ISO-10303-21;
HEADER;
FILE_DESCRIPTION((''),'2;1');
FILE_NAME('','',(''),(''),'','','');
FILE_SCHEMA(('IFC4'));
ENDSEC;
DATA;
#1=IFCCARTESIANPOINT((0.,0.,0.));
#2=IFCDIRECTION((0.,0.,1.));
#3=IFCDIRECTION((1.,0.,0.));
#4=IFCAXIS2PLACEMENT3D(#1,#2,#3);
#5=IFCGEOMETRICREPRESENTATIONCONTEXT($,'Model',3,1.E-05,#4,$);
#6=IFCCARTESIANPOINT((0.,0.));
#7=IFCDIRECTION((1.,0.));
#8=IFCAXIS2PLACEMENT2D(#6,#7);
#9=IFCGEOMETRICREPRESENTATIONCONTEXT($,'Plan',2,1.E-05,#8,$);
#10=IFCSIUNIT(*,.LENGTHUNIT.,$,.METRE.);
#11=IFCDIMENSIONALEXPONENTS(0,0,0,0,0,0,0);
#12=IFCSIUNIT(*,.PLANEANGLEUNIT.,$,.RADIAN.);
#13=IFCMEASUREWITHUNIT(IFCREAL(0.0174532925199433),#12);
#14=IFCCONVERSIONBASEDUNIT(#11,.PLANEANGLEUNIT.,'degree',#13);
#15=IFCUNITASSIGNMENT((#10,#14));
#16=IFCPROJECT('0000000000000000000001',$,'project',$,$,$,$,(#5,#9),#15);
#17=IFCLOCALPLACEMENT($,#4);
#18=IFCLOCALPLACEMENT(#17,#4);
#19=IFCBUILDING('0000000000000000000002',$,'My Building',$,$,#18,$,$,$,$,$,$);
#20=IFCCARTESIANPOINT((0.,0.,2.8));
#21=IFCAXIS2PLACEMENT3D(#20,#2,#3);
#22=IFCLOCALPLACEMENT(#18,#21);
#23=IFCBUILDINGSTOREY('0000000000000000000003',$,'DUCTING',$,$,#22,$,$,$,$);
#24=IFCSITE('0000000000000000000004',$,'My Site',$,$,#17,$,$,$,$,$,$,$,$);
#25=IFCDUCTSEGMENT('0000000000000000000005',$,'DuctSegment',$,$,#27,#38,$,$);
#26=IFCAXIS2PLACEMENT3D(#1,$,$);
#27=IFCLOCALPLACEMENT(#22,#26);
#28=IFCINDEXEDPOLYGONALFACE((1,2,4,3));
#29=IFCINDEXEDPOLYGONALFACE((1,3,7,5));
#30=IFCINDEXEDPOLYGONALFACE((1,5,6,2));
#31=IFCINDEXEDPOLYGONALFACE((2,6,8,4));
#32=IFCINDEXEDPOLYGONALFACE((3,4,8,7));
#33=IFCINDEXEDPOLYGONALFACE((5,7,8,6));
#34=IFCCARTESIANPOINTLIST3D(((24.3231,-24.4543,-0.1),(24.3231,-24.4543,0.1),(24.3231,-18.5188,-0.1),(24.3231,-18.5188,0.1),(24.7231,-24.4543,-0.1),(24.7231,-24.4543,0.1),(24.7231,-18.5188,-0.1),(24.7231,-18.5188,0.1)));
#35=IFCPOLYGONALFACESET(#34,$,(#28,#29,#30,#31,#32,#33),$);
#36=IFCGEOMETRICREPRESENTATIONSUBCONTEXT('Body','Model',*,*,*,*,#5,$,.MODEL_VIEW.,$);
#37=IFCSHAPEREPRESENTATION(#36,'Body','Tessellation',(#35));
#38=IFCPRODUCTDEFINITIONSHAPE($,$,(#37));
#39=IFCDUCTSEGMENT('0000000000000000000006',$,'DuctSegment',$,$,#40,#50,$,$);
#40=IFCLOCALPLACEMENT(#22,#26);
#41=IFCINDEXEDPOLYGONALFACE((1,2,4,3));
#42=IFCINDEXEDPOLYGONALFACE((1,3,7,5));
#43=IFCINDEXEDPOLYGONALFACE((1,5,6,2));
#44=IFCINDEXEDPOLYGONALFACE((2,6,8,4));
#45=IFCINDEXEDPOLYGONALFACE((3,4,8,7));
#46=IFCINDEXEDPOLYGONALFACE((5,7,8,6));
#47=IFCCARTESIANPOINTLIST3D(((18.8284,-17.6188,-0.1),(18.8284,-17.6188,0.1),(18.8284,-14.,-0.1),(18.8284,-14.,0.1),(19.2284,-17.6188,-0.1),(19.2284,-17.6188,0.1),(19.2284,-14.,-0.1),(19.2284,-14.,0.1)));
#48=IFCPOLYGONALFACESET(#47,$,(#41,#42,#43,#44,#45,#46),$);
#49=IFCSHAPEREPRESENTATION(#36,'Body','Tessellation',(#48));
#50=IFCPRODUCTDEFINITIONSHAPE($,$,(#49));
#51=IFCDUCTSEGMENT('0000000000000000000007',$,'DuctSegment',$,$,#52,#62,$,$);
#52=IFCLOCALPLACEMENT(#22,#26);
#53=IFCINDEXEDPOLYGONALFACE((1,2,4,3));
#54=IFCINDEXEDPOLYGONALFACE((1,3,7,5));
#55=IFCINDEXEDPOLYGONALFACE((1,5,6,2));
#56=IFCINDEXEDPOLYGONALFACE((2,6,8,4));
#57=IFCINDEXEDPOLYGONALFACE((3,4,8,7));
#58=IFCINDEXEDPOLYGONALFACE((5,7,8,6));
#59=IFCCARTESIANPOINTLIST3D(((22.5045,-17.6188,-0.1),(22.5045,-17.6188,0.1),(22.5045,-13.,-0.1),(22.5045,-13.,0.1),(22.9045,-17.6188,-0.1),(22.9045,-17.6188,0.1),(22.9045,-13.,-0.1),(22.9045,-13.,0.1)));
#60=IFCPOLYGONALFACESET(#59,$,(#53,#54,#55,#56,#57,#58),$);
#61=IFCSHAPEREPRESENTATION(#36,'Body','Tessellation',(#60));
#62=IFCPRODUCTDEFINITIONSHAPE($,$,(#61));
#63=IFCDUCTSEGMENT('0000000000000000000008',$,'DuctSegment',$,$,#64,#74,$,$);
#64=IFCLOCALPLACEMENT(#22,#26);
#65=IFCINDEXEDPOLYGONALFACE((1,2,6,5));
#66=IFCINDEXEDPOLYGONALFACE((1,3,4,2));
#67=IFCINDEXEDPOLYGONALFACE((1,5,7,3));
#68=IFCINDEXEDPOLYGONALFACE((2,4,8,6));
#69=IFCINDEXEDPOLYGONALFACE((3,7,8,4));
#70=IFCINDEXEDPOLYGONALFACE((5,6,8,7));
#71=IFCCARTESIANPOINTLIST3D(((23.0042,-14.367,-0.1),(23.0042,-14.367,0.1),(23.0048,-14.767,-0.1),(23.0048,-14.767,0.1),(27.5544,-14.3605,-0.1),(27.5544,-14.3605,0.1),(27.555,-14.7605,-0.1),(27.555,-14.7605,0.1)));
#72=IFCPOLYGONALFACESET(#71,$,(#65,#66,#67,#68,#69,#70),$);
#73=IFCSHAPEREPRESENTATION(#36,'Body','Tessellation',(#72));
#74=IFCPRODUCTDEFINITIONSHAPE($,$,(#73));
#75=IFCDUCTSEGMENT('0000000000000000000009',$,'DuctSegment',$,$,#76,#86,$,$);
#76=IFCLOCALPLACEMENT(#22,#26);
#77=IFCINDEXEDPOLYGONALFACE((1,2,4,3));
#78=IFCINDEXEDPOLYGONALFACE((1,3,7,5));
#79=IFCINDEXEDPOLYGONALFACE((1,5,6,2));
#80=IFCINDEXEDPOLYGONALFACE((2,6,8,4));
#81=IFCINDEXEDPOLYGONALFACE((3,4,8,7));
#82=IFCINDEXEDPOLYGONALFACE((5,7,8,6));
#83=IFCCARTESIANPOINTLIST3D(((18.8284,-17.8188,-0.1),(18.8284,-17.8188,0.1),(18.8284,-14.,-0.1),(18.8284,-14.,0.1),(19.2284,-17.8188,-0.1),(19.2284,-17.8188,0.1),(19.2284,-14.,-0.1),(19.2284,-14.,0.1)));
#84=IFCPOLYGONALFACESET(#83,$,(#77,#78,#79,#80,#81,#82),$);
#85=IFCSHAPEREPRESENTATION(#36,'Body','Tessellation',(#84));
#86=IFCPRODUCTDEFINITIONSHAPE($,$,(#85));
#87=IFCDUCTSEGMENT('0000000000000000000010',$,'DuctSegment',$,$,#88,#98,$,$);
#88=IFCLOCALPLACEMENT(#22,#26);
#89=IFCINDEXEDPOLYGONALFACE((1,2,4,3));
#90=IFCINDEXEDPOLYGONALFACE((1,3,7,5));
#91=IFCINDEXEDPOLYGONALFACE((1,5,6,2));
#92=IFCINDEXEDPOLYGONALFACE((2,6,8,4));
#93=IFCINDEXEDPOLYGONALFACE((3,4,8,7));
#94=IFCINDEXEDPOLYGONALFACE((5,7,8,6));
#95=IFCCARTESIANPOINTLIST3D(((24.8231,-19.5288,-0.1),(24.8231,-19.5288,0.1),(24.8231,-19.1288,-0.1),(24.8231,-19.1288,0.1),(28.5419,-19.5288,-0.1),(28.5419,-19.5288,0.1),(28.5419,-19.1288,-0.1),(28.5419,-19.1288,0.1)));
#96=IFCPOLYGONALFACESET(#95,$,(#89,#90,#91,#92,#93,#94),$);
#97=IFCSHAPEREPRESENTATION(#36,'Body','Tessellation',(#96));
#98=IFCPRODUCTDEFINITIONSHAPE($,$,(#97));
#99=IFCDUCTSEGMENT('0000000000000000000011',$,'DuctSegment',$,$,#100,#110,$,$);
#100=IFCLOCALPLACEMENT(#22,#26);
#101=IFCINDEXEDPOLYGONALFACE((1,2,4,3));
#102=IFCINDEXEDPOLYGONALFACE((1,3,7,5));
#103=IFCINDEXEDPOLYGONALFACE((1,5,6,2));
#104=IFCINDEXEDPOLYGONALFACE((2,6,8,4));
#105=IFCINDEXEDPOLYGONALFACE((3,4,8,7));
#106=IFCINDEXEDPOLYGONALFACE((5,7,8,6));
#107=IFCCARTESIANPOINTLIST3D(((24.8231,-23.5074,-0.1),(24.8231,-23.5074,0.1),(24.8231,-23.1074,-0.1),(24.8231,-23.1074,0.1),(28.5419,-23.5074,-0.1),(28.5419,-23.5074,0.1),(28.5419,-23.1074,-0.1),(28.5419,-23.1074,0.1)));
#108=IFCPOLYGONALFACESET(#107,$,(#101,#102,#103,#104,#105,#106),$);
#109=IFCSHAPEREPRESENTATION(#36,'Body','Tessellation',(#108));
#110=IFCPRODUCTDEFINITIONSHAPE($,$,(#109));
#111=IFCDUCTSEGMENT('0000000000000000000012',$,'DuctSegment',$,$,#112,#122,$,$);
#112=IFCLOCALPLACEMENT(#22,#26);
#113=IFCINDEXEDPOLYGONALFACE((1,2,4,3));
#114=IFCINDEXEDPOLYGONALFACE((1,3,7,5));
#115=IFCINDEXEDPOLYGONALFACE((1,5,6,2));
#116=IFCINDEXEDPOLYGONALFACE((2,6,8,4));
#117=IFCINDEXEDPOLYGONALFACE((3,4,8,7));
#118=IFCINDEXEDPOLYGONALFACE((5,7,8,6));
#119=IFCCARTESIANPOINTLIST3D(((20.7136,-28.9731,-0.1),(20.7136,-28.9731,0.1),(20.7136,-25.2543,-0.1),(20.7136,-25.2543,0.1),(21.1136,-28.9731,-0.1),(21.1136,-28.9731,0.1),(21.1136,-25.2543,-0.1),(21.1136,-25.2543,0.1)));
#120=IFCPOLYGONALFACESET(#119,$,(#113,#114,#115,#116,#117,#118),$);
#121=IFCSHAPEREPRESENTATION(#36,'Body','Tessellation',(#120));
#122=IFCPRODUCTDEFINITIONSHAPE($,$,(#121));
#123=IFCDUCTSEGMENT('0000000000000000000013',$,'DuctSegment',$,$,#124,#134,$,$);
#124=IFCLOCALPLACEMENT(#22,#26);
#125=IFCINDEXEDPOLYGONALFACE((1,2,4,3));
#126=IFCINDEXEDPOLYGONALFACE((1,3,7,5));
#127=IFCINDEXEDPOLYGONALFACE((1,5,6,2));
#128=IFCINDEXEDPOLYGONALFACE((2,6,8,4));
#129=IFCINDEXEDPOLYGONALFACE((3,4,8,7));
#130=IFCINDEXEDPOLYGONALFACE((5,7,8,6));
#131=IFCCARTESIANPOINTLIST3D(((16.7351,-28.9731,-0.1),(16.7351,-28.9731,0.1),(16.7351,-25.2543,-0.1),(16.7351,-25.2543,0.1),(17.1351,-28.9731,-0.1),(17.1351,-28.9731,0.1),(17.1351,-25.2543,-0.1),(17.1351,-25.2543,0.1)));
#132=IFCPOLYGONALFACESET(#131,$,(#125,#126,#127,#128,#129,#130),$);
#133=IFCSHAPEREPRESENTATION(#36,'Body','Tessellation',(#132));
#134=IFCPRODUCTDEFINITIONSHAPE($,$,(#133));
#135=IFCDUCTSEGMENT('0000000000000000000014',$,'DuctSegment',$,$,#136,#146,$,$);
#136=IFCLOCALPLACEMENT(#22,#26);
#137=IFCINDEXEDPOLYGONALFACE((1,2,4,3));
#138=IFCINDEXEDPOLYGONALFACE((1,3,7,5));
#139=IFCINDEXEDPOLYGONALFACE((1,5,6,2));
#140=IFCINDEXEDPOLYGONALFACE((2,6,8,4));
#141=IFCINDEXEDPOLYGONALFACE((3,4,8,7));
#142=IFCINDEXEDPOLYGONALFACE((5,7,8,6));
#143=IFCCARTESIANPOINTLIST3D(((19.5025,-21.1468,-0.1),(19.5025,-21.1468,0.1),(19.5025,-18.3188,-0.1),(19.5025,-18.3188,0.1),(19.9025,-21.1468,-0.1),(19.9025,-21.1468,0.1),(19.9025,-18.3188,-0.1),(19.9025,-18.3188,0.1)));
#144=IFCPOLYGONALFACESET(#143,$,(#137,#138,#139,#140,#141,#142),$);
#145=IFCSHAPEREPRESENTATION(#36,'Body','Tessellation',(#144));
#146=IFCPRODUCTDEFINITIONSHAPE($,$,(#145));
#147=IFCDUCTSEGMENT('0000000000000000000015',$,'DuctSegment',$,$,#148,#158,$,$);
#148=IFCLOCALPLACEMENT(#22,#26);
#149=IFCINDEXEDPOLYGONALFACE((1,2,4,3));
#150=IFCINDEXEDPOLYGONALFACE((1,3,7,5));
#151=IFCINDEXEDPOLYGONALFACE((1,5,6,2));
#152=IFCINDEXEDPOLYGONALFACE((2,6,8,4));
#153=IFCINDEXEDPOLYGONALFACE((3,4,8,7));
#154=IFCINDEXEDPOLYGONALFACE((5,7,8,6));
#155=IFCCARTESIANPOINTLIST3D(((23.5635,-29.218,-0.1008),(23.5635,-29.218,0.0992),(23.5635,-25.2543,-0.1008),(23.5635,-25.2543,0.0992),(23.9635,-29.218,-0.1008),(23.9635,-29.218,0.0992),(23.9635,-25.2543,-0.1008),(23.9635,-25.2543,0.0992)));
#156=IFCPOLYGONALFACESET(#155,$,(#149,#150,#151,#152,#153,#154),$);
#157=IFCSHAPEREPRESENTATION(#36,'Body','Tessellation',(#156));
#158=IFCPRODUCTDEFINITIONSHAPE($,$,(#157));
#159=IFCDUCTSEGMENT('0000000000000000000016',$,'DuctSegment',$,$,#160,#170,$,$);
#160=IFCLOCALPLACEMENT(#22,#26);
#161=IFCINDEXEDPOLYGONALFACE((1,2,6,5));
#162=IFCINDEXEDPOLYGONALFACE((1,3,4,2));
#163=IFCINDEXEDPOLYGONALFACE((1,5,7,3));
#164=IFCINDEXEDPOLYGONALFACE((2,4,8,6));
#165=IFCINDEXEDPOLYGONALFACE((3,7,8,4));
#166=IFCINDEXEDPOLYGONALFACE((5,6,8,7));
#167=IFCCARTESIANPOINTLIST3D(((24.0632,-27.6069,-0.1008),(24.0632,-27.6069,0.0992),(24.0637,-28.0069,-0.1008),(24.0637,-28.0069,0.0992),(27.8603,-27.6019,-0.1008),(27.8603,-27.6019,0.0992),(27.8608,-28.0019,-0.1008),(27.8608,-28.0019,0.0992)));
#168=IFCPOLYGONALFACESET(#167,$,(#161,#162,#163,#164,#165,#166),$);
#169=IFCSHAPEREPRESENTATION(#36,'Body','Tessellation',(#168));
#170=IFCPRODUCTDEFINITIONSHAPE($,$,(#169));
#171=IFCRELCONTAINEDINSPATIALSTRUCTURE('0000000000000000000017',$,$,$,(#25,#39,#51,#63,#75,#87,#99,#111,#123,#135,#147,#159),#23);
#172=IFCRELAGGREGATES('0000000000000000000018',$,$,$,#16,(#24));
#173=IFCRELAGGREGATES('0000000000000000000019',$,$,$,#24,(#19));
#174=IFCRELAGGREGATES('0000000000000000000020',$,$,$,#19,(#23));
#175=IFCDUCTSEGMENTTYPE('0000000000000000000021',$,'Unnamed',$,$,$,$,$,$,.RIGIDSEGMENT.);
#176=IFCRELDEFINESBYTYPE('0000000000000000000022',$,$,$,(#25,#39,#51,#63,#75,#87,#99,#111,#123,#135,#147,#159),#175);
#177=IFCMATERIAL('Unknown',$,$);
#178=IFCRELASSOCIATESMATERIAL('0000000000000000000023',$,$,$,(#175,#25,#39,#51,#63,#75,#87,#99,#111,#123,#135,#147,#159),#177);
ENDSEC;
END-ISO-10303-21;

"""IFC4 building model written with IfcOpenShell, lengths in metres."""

from ifc_helpers import new_model, entity, si_unit, converted_unit, frame, origin_with_axes, origin_2d_with_axis, place, context, subcontext, project, spatial, rectangle, extrude, material, material_profile, profile_set, profile_usage, type_object, element, save


model = new_model("IFC4")

# Units and contexts
model_context = context("Model", 3, precision=1e-05, world=origin_with_axes())
plan_context = context("Plan", 2, precision=1e-05, world=origin_2d_with_axis())
body_context = subcontext(model_context, "Body", "Model", "MODEL_VIEW")
ifc_project = project(units=[si_unit("LENGTHUNIT", "METRE"), converted_unit("PLANEANGLEUNIT", "degree", entity("IfcReal", 0.0174532925199433), si_unit("PLANEANGLEUNIT", "RADIAN"), dimensions=[0, 0, 0, 0, 0, 0, 0])], contexts=[model_context, plan_context])

# Site, building, storey
site_placement = place(None, origin_with_axes())
site = spatial("IfcSite", under=ifc_project, at=site_placement, Name="My Site")
building_placement = place(site_placement, origin_with_axes())
building = spatial("IfcBuilding", under=site, at=building_placement, Name="My Building")
storey_placement = place(building_placement, frame((0.0, 0.0, 2.8), z_axis=(0.0, 0.0, 1.0), x_axis=(1.0, 0.0, 0.0)))
storey = spatial("IfcBuildingStorey", under=building, at=storey_placement, Name="DUCTING")

# Duct segments
ifc_material = material(Name="Unknown")
ifc_material_profile_1 = material_profile(ifc_material, rectangle(XDim=0.4, YDim=0.2))
ifc_profile_set_1 = profile_set([ifc_material_profile_1])
ifc_profile_usage_1 = profile_usage(ifc_profile_set_1, cardinal=5)
duct_segment_type = type_object("IfcDuctSegmentType", Name="Unnamed", PredefinedType="RIGIDSEGMENT", material=ifc_profile_set_1)
duct_segment_1_placement = place(storey_placement, frame((24.5231, -18.5188, 0.0), z_axis=(0.000006, -1.0, 0.0), x_axis=(1.0, 0.000006, 0.0)))
element("IfcDuctSegment", 1, at=duct_segment_1_placement, inside=storey, type_object=duct_segment_type, material=ifc_profile_usage_1, Name="DuctSegment", context=body_context, shape_type="SweptSolid", body=[
    extrude(rectangle(XDim=0.4, YDim=0.2), origin_with_axes(), (0.0, 0.0, 1.0), 5.9355),
])
ifc_profile_usage_2 = profile_usage(ifc_profile_set_1, cardinal=5)
duct_segment_2_placement = place(storey_placement, frame((19.0284, -17.6188, 0.0), z_axis=(0.0, 1.0, 0.0), x_axis=(-1.0, 0.0, 0.0)))
element("IfcDuctSegment", 2, at=duct_segment_2_placement, inside=storey, type_object=duct_segment_type, material=ifc_profile_usage_2, Name="DuctSegment", context=body_context, shape_type="SweptSolid", body=[
    extrude(rectangle(XDim=0.4, YDim=0.2), origin_with_axes(), (0.0, 0.0, 1.0), 3.6188),
])
ifc_profile_usage_3 = profile_usage(ifc_profile_set_1, cardinal=5)
duct_segment_3_placement = place(storey_placement, frame((22.7045, -17.6188, 0.0), z_axis=(0.0, 1.0, 0.0), x_axis=(-1.0, 0.0, 0.0)))
element("IfcDuctSegment", 3, at=duct_segment_3_placement, inside=storey, type_object=duct_segment_type, material=ifc_profile_usage_3, Name="DuctSegment", context=body_context, shape_type="SweptSolid", body=[
    extrude(rectangle(XDim=0.4, YDim=0.2), origin_with_axes(), (0.0, 0.0, 1.0), 4.6188),
])
ifc_profile_usage_4 = profile_usage(ifc_profile_set_1, cardinal=5)
duct_segment_4_placement = place(storey_placement, frame((23.0045, -14.567, 0.0), z_axis=(0.999999, 0.001427, 0.0), x_axis=(-0.001427, 0.999999, 0.0)))
element("IfcDuctSegment", 4, at=duct_segment_4_placement, inside=storey, type_object=duct_segment_type, material=ifc_profile_usage_4, Name="DuctSegment", context=body_context, shape_type="SweptSolid", body=[
    extrude(rectangle(XDim=0.4, YDim=0.2), origin_with_axes(), (0.0, 0.0, 1.0), 4.5502),
])
ifc_profile_usage_5 = profile_usage(ifc_profile_set_1, cardinal=5)
duct_segment_5_placement = place(storey_placement, frame((19.0284, -17.8188, 0.0), z_axis=(0.0, 1.0, 0.0), x_axis=(-1.0, 0.0, 0.0)))
element("IfcDuctSegment", 5, at=duct_segment_5_placement, inside=storey, type_object=duct_segment_type, material=ifc_profile_usage_5, Name="DuctSegment", context=body_context, shape_type="SweptSolid", body=[
    extrude(rectangle(XDim=0.4, YDim=0.2), origin_with_axes(), (0.0, 0.0, 1.0), 3.8188),
])
ifc_profile_usage_6 = profile_usage(ifc_profile_set_1, cardinal=5)
duct_segment_6_placement = place(storey_placement, frame((24.8231, -19.3288, 0.0), z_axis=(1.0, 0.0, 0.0), x_axis=(0.0, 1.0, 0.0)))
element("IfcDuctSegment", 6, at=duct_segment_6_placement, inside=storey, type_object=duct_segment_type, material=ifc_profile_usage_6, Name="DuctSegment", context=body_context, shape_type="SweptSolid", body=[
    extrude(rectangle(XDim=0.4, YDim=0.2), origin_with_axes(), (0.0, 0.0, 1.0), 3.7188),
])
ifc_profile_usage_7 = profile_usage(ifc_profile_set_1, cardinal=5)
duct_segment_7_placement = place(storey_placement, frame((24.8231, -23.3074, 0.0), z_axis=(1.0, 0.0, 0.0), x_axis=(0.0, 1.0, 0.0)))
element("IfcDuctSegment", 7, at=duct_segment_7_placement, inside=storey, type_object=duct_segment_type, material=ifc_profile_usage_7, Name="DuctSegment", context=body_context, shape_type="SweptSolid", body=[
    extrude(rectangle(XDim=0.4, YDim=0.2), origin_with_axes(), (0.0, 0.0, 1.0), 3.7188),
])
ifc_profile_usage_8 = profile_usage(ifc_profile_set_1, cardinal=5)
duct_segment_8_placement = place(storey_placement, frame((20.9136, -25.2543, 0.0), z_axis=(0.0, -1.0, 0.0), x_axis=(1.0, 0.0, 0.0)))
element("IfcDuctSegment", 8, at=duct_segment_8_placement, inside=storey, type_object=duct_segment_type, material=ifc_profile_usage_8, Name="DuctSegment", context=body_context, shape_type="SweptSolid", body=[
    extrude(rectangle(XDim=0.4, YDim=0.2), origin_with_axes(), (0.0, 0.0, 1.0), 3.7188),
])
ifc_profile_usage_9 = profile_usage(ifc_profile_set_1, cardinal=5)
duct_segment_9_placement = place(storey_placement, frame((16.9351, -25.2543, 0.0), z_axis=(0.0, -1.0, 0.0), x_axis=(1.0, 0.0, 0.0)))
element("IfcDuctSegment", 9, at=duct_segment_9_placement, inside=storey, type_object=duct_segment_type, material=ifc_profile_usage_9, Name="DuctSegment", context=body_context, shape_type="SweptSolid", body=[
    extrude(rectangle(XDim=0.4, YDim=0.2), origin_with_axes(), (0.0, 0.0, 1.0), 3.7188),
])
ifc_profile_usage_10 = profile_usage(ifc_profile_set_1, cardinal=5)
duct_segment_10_placement = place(storey_placement, frame((19.7025, -18.3188, 0.0), z_axis=(0.0, -1.0, 0.0), x_axis=(1.0, 0.0, 0.0)))
element("IfcDuctSegment", 10, at=duct_segment_10_placement, inside=storey, type_object=duct_segment_type, material=ifc_profile_usage_10, Name="DuctSegment", context=body_context, shape_type="SweptSolid", body=[
    extrude(rectangle(XDim=0.4, YDim=0.2), origin_with_axes(), (0.0, 0.0, 1.0), 2.828),
])
ifc_profile_usage_11 = profile_usage(ifc_profile_set_1, cardinal=5)
duct_segment_11_placement = place(storey_placement, frame((23.7635, -25.2543, -0.0008), z_axis=(0.0, -1.0, 0.0), x_axis=(1.0, 0.0, 0.0)))
element("IfcDuctSegment", 11, at=duct_segment_11_placement, inside=storey, type_object=duct_segment_type, material=ifc_profile_usage_11, Name="DuctSegment", context=body_context, shape_type="SweptSolid", body=[
    extrude(rectangle(XDim=0.4, YDim=0.2), origin_with_axes(), (0.0, 0.0, 1.0), 3.9636),
])
ifc_profile_usage_12 = profile_usage(ifc_profile_set_1, cardinal=5)
duct_segment_12_placement = place(storey_placement, frame((24.0635, -27.8069, -0.0008), z_axis=(0.999999, 0.001336, 0.0), x_axis=(-0.001336, 0.999999, 0.0)))
element("IfcDuctSegment", 12, at=duct_segment_12_placement, inside=storey, type_object=duct_segment_type, material=ifc_profile_usage_12, Name="DuctSegment", context=body_context, shape_type="SweptSolid", body=[
    extrude(rectangle(XDim=0.4, YDim=0.2), origin_with_axes(), (0.0, 0.0, 1.0), 3.7971),
])

save(model, "model.ifc")
